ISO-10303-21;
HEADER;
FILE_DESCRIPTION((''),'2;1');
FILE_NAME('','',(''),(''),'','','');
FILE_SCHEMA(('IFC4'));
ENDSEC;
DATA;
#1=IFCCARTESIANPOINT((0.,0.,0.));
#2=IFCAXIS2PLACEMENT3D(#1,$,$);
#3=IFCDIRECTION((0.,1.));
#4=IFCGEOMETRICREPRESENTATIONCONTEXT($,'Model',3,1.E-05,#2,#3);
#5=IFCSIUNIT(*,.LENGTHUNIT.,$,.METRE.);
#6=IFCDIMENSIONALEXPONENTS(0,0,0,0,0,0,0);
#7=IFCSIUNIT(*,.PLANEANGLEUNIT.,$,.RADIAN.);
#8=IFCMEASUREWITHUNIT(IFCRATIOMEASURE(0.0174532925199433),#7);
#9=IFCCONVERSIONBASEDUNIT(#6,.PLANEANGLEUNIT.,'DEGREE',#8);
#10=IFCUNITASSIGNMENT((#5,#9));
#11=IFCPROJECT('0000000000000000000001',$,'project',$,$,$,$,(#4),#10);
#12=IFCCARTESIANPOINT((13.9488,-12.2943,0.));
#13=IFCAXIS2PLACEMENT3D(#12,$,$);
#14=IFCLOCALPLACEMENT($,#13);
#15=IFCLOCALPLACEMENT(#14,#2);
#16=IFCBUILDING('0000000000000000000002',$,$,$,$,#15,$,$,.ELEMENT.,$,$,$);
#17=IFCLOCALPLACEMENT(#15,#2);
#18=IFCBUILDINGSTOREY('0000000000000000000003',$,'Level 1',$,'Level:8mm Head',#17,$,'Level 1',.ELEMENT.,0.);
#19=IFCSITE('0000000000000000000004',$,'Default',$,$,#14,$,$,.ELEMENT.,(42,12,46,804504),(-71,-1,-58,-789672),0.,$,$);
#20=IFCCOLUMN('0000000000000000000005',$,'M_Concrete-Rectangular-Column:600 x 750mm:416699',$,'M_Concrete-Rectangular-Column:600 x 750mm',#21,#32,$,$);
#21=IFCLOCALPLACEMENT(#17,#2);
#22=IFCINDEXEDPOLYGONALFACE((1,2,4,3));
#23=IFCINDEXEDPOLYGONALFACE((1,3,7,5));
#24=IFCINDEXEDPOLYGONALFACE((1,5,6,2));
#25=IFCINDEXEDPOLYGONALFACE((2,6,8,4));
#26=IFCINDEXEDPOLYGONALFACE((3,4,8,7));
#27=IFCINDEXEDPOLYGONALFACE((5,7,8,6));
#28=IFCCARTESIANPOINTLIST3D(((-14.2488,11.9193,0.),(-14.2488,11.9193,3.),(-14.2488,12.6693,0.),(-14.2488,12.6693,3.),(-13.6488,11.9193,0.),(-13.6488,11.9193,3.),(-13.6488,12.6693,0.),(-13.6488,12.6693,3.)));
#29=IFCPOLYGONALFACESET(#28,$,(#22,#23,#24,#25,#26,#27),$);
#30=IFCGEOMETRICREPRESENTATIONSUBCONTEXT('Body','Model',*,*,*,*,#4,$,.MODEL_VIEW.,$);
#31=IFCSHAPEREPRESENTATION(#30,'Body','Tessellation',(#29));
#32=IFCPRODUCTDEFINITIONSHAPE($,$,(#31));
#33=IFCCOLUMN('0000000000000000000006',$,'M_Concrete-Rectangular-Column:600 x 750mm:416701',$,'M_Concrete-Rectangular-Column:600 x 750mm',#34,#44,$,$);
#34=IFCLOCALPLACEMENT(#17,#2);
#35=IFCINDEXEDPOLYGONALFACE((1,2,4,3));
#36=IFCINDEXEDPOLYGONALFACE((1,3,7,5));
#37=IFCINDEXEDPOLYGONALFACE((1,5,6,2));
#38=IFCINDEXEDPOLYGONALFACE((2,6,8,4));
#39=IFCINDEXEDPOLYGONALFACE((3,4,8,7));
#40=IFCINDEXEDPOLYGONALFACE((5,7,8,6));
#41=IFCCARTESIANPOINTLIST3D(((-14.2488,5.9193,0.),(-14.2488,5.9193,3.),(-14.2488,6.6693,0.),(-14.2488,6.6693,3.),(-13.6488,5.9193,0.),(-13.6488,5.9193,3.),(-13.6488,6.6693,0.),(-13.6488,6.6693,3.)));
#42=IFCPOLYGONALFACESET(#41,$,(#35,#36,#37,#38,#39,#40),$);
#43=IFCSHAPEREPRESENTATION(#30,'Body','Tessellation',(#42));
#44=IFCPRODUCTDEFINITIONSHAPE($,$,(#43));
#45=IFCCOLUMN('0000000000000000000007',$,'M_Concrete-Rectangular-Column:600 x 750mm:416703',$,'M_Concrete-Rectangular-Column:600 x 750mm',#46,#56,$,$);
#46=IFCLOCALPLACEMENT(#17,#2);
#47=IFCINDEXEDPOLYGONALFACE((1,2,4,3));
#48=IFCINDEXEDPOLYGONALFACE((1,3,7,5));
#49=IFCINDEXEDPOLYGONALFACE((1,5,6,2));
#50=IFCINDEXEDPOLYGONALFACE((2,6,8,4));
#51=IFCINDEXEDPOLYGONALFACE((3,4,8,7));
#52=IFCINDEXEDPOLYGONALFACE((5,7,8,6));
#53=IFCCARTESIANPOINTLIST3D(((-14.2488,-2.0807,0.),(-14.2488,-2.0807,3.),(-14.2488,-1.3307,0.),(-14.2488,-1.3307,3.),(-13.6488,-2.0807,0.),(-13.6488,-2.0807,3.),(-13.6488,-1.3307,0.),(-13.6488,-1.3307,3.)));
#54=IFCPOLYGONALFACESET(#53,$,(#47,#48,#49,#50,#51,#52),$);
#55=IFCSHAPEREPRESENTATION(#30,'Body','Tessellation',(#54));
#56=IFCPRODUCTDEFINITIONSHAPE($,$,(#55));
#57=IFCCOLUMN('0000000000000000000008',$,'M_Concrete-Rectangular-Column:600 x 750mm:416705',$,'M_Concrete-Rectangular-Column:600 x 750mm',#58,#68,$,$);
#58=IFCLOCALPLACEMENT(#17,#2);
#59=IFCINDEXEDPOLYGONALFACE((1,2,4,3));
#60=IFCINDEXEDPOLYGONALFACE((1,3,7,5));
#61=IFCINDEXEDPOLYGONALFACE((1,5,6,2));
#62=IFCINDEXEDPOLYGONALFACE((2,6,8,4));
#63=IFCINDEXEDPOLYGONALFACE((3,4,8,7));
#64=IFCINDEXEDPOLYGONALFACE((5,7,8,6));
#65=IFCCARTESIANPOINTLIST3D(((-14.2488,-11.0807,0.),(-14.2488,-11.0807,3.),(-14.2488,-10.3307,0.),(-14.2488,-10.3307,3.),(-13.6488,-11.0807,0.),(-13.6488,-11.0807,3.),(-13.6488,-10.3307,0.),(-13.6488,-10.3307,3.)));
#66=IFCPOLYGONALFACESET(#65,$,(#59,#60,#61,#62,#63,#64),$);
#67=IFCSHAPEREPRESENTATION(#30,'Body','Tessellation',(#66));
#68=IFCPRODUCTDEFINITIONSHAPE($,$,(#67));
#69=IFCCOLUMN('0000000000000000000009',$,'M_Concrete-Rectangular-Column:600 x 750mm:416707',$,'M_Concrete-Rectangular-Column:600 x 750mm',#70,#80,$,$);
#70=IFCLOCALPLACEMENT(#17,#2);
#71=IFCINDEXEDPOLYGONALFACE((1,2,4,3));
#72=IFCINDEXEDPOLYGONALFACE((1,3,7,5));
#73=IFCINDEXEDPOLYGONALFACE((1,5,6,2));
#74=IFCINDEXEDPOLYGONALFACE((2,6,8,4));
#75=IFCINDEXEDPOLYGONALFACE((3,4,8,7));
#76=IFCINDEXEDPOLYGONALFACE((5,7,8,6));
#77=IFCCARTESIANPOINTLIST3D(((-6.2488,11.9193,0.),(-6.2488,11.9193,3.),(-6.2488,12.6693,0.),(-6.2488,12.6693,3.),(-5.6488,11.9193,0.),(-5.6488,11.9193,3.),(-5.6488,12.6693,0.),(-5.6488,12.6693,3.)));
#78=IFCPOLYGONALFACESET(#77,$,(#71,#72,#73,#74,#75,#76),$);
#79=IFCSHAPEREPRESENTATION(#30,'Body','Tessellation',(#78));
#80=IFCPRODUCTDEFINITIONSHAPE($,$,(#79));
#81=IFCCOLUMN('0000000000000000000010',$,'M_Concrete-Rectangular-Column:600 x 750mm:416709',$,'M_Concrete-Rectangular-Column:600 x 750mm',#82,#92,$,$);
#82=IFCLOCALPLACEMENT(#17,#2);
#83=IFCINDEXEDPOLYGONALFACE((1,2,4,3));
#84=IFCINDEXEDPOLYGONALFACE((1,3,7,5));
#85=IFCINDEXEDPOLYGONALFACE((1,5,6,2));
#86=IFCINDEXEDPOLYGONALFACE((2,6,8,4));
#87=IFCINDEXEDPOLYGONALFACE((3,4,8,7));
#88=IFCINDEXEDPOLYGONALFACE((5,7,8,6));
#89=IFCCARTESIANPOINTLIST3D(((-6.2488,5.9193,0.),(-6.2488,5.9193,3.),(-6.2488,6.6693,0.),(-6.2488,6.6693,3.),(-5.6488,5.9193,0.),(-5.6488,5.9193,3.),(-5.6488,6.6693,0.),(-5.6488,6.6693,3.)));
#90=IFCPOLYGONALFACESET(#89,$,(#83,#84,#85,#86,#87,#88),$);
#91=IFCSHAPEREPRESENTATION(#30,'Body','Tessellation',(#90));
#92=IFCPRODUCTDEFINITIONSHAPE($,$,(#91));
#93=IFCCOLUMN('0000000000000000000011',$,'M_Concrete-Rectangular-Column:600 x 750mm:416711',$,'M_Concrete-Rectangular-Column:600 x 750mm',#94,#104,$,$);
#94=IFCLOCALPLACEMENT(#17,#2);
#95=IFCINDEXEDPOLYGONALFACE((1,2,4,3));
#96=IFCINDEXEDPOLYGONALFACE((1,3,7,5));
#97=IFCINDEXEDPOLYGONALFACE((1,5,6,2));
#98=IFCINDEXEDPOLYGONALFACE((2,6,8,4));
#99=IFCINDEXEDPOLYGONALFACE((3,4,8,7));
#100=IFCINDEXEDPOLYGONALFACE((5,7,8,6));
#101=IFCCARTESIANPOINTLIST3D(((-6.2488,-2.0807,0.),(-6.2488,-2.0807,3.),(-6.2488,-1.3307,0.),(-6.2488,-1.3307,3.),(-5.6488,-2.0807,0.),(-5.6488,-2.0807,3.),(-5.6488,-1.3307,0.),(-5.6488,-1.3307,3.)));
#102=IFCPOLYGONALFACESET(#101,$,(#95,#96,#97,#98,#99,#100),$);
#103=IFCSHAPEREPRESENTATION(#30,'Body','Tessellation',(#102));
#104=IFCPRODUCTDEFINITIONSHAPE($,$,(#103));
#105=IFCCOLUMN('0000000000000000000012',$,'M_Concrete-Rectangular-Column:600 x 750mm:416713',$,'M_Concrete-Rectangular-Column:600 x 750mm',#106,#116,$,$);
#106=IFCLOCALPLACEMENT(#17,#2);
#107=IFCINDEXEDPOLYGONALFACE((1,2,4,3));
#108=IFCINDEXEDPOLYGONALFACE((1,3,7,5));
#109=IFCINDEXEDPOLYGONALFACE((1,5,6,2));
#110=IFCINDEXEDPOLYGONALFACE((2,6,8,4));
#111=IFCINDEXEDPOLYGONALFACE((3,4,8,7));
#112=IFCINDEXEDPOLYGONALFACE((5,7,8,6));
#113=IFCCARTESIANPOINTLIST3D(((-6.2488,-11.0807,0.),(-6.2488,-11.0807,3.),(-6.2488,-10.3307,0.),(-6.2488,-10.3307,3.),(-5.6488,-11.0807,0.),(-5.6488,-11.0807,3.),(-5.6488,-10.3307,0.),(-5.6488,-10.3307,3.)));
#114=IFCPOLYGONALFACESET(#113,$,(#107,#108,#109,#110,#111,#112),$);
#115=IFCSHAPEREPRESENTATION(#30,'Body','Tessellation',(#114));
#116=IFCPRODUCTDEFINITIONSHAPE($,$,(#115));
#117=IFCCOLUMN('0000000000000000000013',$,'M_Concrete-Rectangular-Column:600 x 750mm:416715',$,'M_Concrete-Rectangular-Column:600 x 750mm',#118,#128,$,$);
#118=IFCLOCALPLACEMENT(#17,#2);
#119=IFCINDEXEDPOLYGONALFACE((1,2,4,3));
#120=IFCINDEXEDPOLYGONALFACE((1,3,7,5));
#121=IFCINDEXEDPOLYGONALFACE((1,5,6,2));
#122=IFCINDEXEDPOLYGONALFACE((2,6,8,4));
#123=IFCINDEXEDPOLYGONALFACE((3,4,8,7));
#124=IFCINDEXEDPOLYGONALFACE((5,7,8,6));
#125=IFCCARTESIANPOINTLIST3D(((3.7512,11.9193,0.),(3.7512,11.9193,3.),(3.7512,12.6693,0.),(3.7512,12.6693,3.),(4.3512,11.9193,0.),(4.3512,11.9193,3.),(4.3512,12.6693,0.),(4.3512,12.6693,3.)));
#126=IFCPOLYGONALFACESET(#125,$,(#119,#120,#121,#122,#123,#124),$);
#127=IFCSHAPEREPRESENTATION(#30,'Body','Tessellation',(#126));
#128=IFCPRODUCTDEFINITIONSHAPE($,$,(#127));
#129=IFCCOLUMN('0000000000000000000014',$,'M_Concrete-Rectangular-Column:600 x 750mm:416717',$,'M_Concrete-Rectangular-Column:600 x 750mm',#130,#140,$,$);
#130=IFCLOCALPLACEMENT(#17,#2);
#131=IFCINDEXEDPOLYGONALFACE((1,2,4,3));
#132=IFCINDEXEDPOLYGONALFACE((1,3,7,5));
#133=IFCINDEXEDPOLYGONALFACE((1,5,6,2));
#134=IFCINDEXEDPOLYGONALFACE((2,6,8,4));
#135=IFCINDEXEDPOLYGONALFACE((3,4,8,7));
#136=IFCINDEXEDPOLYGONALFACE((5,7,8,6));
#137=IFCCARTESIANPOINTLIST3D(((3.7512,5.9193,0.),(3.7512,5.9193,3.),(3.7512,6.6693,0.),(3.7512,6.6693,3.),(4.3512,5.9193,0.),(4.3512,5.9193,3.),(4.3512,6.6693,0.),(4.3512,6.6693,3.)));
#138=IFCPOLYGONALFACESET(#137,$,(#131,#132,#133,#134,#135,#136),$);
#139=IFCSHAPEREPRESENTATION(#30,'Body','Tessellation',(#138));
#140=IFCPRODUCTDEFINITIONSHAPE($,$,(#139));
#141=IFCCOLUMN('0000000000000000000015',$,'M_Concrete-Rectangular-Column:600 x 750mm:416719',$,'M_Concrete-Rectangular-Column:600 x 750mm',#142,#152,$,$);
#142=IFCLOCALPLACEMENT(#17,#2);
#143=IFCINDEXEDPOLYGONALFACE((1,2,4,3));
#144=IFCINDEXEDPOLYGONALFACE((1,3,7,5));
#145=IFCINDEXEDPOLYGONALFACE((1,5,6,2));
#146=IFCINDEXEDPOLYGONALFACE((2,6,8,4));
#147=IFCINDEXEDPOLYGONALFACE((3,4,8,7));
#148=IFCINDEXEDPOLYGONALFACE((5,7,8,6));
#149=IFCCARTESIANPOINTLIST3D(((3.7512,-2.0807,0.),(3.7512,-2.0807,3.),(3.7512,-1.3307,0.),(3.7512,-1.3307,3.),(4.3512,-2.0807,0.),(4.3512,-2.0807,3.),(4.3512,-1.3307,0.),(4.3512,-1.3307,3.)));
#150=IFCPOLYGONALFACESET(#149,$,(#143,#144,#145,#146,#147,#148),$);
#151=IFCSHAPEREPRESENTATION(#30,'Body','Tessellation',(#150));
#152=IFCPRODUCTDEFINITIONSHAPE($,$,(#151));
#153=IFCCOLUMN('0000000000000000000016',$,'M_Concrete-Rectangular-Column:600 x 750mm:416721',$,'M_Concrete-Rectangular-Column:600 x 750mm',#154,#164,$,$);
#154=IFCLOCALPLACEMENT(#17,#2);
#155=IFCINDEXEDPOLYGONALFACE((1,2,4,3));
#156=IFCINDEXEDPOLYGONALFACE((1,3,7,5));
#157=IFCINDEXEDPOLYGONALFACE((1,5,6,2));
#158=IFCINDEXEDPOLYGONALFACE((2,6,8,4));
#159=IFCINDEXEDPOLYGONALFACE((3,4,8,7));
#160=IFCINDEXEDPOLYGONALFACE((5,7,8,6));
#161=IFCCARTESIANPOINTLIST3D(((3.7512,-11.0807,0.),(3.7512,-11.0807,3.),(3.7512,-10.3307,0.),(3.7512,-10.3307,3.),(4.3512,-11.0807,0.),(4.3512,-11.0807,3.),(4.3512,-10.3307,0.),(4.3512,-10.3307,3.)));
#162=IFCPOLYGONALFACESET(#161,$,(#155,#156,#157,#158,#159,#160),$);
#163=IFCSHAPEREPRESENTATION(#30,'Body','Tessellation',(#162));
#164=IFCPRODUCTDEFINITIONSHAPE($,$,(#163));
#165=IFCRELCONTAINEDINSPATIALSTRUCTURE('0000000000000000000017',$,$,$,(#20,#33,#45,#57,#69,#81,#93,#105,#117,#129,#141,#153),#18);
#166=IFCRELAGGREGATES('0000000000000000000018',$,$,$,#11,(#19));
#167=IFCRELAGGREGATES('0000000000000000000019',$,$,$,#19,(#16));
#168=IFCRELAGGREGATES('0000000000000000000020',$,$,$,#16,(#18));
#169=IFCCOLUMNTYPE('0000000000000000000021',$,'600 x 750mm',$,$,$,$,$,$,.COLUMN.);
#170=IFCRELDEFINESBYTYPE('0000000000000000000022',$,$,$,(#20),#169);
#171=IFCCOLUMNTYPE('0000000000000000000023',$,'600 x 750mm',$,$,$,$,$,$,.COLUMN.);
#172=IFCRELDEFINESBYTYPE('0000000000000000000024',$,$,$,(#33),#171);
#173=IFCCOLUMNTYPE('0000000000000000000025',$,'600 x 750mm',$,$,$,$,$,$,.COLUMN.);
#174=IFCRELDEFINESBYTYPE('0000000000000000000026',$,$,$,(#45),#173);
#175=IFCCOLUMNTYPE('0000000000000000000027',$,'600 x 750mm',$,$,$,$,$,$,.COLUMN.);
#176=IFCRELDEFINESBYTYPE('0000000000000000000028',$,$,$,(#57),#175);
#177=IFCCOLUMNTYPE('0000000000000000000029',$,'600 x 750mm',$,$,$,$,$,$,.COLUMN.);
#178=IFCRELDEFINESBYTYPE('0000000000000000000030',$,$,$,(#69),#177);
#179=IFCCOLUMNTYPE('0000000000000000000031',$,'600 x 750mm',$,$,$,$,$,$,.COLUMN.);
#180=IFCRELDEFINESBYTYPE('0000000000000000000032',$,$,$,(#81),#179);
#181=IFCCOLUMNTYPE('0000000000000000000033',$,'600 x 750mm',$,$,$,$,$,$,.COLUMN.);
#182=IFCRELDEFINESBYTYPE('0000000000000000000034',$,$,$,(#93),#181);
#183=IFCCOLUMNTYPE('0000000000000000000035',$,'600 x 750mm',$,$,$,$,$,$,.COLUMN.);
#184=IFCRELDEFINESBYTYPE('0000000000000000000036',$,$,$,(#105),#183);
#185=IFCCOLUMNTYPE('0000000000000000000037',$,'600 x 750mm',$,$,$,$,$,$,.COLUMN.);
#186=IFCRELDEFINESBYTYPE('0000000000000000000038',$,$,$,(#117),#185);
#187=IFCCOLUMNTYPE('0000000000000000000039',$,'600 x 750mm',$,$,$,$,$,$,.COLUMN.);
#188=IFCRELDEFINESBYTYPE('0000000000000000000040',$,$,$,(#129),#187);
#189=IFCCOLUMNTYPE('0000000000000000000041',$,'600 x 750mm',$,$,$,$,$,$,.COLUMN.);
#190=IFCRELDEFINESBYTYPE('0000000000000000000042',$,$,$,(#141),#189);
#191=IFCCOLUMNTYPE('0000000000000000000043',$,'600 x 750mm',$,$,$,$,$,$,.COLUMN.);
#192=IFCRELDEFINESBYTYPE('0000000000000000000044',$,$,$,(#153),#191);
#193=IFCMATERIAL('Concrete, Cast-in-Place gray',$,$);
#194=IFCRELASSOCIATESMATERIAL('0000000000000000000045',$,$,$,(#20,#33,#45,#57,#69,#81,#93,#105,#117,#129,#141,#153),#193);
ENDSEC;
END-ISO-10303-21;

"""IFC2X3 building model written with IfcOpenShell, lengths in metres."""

from ifc_helpers import new_model, entity, si_unit, converted_unit, direction, frame, frame_2d, origin, origin_2d_with_axis, place, context, subcontext, project, spatial, rectangle, extrude, source, transform, mapped, material, type_object, type_shapes, element, save


model = new_model("IFC2X3")

# Units and contexts
model_context = context("Model", 3, precision=1e-05, world=origin(), true_north=direction((0.0, 1.0)))
body_context = subcontext(model_context, "Body", "Model", "MODEL_VIEW")
ifc_project = project(units=[si_unit("LENGTHUNIT", "METRE"), converted_unit("PLANEANGLEUNIT", "DEGREE", entity("IfcRatioMeasure", 0.0174532925199433), si_unit("PLANEANGLEUNIT", "RADIAN"), dimensions=[0, 0, 0, 0, 0, 0, 0])], contexts=[model_context])

# Site, building, storey
site_placement = place(None, frame((13.9488, -12.2943, 0.0)))
site = spatial("IfcSite", under=ifc_project, at=site_placement, Name="Default", CompositionType="ELEMENT", RefLatitude=(42, 12, 46, 804504), RefLongitude=(-71, -1, -58, -789672), RefElevation=0.0)
building_placement = place(site_placement, origin())
building = spatial("IfcBuilding", under=site, at=building_placement, CompositionType="ELEMENT")
storey_placement = place(building_placement, origin())
storey = spatial("IfcBuildingStorey", under=building, at=storey_placement, Name="Level 1", ObjectType="Level:8mm Head", LongName="Level 1", CompositionType="ELEMENT", Elevation=0.0)

# Columns
ifc_material = material(Name="Concrete, Cast-in-Place gray")
column_type_1 = type_object("IfcColumnType", Name="600 x 750mm", PredefinedType="COLUMN")
shared_shape_1 = source(origin(), body_context, "Body", "SweptSolid", [
    extrude(rectangle(XDim=0.75, YDim=0.6, at=frame_2d((0.0, 0.0), x_axis=(1.0, 0.0))), frame((-13.9488, 12.2943, 0.0), z_axis=(0.0, 0.0, 1.0), x_axis=(0.0, -1.0, 0.0)), (0.0, 0.0, 1.0), 3.0),
])
type_shapes(column_type_1, [shared_shape_1])
column_1_placement = place(storey_placement, origin())
element("IfcColumn", 1, at=column_1_placement, inside=storey, type_object=column_type_1, material=ifc_material, Name="M_Concrete-Rectangular-Column:600 x 750mm:416699", ObjectType="M_Concrete-Rectangular-Column:600 x 750mm", context=body_context, shape_type="MappedRepresentation", body=[
    mapped(shared_shape_1, transform((0.0, 0.0, 0.0), scale=1.0)),
])
column_type_2 = type_object("IfcColumnType", Name="600 x 750mm", PredefinedType="COLUMN")
shared_shape_2 = source(origin(), body_context, "Body", "SweptSolid", [
    extrude(rectangle(XDim=0.75, YDim=0.6, at=frame_2d((0.0, 0.0), x_axis=(1.0, 0.0))), frame((-13.9488, 6.2943, 0.0), z_axis=(0.0, 0.0, 1.0), x_axis=(0.0, -1.0, 0.0)), (0.0, 0.0, 1.0), 3.0),
])
type_shapes(column_type_2, [shared_shape_2])
column_2_placement = place(storey_placement, origin())
element("IfcColumn", 2, at=column_2_placement, inside=storey, type_object=column_type_2, material=ifc_material, Name="M_Concrete-Rectangular-Column:600 x 750mm:416701", ObjectType="M_Concrete-Rectangular-Column:600 x 750mm", context=body_context, shape_type="MappedRepresentation", body=[
    mapped(shared_shape_2, transform((0.0, 0.0, 0.0), scale=1.0)),
])
column_type_3 = type_object("IfcColumnType", Name="600 x 750mm", PredefinedType="COLUMN")
shared_shape_3 = source(origin(), body_context, "Body", "SweptSolid", [
    extrude(rectangle(XDim=0.75, YDim=0.6, at=frame_2d((0.0, 0.0), x_axis=(1.0, 0.0))), frame((-13.9488, -1.7057, 0.0), z_axis=(0.0, 0.0, 1.0), x_axis=(0.0, -1.0, 0.0)), (0.0, 0.0, 1.0), 3.0),
])
type_shapes(column_type_3, [shared_shape_3])
column_3_placement = place(storey_placement, origin())
element("IfcColumn", 3, at=column_3_placement, inside=storey, type_object=column_type_3, material=ifc_material, Name="M_Concrete-Rectangular-Column:600 x 750mm:416703", ObjectType="M_Concrete-Rectangular-Column:600 x 750mm", context=body_context, shape_type="MappedRepresentation", body=[
    mapped(shared_shape_3, transform((0.0, 0.0, 0.0), scale=1.0)),
])
column_type_4 = type_object("IfcColumnType", Name="600 x 750mm", PredefinedType="COLUMN")
shared_shape_4 = source(origin(), body_context, "Body", "SweptSolid", [
    extrude(rectangle(XDim=0.75, YDim=0.6, at=frame_2d((0.0, 0.0), x_axis=(1.0, 0.0))), frame((-13.9488, -10.7057, 0.0), z_axis=(0.0, 0.0, 1.0), x_axis=(0.0, -1.0, 0.0)), (0.0, 0.0, 1.0), 3.0),
])
type_shapes(column_type_4, [shared_shape_4])
column_4_placement = place(storey_placement, origin())
element("IfcColumn", 4, at=column_4_placement, inside=storey, type_object=column_type_4, material=ifc_material, Name="M_Concrete-Rectangular-Column:600 x 750mm:416705", ObjectType="M_Concrete-Rectangular-Column:600 x 750mm", context=body_context, shape_type="MappedRepresentation", body=[
    mapped(shared_shape_4, transform((0.0, 0.0, 0.0), scale=1.0)),
])
column_type_5 = type_object("IfcColumnType", Name="600 x 750mm", PredefinedType="COLUMN")
shared_shape_5 = source(origin(), body_context, "Body", "SweptSolid", [
    extrude(rectangle(XDim=0.75, YDim=0.6, at=origin_2d_with_axis()), frame((-5.9488, 12.2943, 0.0), z_axis=(0.0, 0.0, 1.0), x_axis=(0.0, -1.0, 0.0)), (0.0, 0.0, 1.0), 3.0),
])
type_shapes(column_type_5, [shared_shape_5])
column_5_placement = place(storey_placement, origin())
element("IfcColumn", 5, at=column_5_placement, inside=storey, type_object=column_type_5, material=ifc_material, Name="M_Concrete-Rectangular-Column:600 x 750mm:416707", ObjectType="M_Concrete-Rectangular-Column:600 x 750mm", context=body_context, shape_type="MappedRepresentation", body=[
    mapped(shared_shape_5, transform((0.0, 0.0, 0.0), scale=1.0)),
])
column_type_6 = type_object("IfcColumnType", Name="600 x 750mm", PredefinedType="COLUMN")
shared_shape_6 = source(origin(), body_context, "Body", "SweptSolid", [
    extrude(rectangle(XDim=0.75, YDim=0.6, at=origin_2d_with_axis()), frame((-5.9488, 6.2943, 0.0), z_axis=(0.0, 0.0, 1.0), x_axis=(0.0, -1.0, 0.0)), (0.0, 0.0, 1.0), 3.0),
])
type_shapes(column_type_6, [shared_shape_6])
column_6_placement = place(storey_placement, origin())
element("IfcColumn", 6, at=column_6_placement, inside=storey, type_object=column_type_6, material=ifc_material, Name="M_Concrete-Rectangular-Column:600 x 750mm:416709", ObjectType="M_Concrete-Rectangular-Column:600 x 750mm", context=body_context, shape_type="MappedRepresentation", body=[
    mapped(shared_shape_6, transform((0.0, 0.0, 0.0), scale=1.0)),
])
column_type_7 = type_object("IfcColumnType", Name="600 x 750mm", PredefinedType="COLUMN")
shared_shape_7 = source(origin(), body_context, "Body", "SweptSolid", [
    extrude(rectangle(XDim=0.75, YDim=0.6, at=frame_2d((0.0, 0.0), x_axis=(1.0, 0.0))), frame((-5.9488, -1.7057, 0.0), z_axis=(0.0, 0.0, 1.0), x_axis=(0.0, -1.0, 0.0)), (0.0, 0.0, 1.0), 3.0),
])
type_shapes(column_type_7, [shared_shape_7])
column_7_placement = place(storey_placement, origin())
element("IfcColumn", 7, at=column_7_placement, inside=storey, type_object=column_type_7, material=ifc_material, Name="M_Concrete-Rectangular-Column:600 x 750mm:416711", ObjectType="M_Concrete-Rectangular-Column:600 x 750mm", context=body_context, shape_type="MappedRepresentation", body=[
    mapped(shared_shape_7, transform((0.0, 0.0, 0.0), scale=1.0)),
])
column_type_8 = type_object("IfcColumnType", Name="600 x 750mm", PredefinedType="COLUMN")
shared_shape_8 = source(origin(), body_context, "Body", "SweptSolid", [
    extrude(rectangle(XDim=0.75, YDim=0.6, at=origin_2d_with_axis()), frame((-5.9488, -10.7057, 0.0), z_axis=(0.0, 0.0, 1.0), x_axis=(0.0, -1.0, 0.0)), (0.0, 0.0, 1.0), 3.0),
])
type_shapes(column_type_8, [shared_shape_8])
column_8_placement = place(storey_placement, origin())
element("IfcColumn", 8, at=column_8_placement, inside=storey, type_object=column_type_8, material=ifc_material, Name="M_Concrete-Rectangular-Column:600 x 750mm:416713", ObjectType="M_Concrete-Rectangular-Column:600 x 750mm", context=body_context, shape_type="MappedRepresentation", body=[
    mapped(shared_shape_8, transform((0.0, 0.0, 0.0), scale=1.0)),
])
column_type_9 = type_object("IfcColumnType", Name="600 x 750mm", PredefinedType="COLUMN")
shared_shape_9 = source(origin(), body_context, "Body", "SweptSolid", [
    extrude(rectangle(XDim=0.75, YDim=0.6, at=origin_2d_with_axis()), frame((4.0512, 12.2943, 0.0), z_axis=(0.0, 0.0, 1.0), x_axis=(0.0, -1.0, 0.0)), (0.0, 0.0, 1.0), 3.0),
])
type_shapes(column_type_9, [shared_shape_9])
column_9_placement = place(storey_placement, origin())
element("IfcColumn", 9, at=column_9_placement, inside=storey, type_object=column_type_9, material=ifc_material, Name="M_Concrete-Rectangular-Column:600 x 750mm:416715", ObjectType="M_Concrete-Rectangular-Column:600 x 750mm", context=body_context, shape_type="MappedRepresentation", body=[
    mapped(shared_shape_9, transform((0.0, 0.0, 0.0), scale=1.0)),
])
column_type_10 = type_object("IfcColumnType", Name="600 x 750mm", PredefinedType="COLUMN")
shared_shape_10 = source(origin(), body_context, "Body", "SweptSolid", [
    extrude(rectangle(XDim=0.75, YDim=0.6, at=origin_2d_with_axis()), frame((4.0512, 6.2943, 0.0), z_axis=(0.0, 0.0, 1.0), x_axis=(0.0, -1.0, 0.0)), (0.0, 0.0, 1.0), 3.0),
])
type_shapes(column_type_10, [shared_shape_10])
column_10_placement = place(storey_placement, origin())
element("IfcColumn", 10, at=column_10_placement, inside=storey, type_object=column_type_10, material=ifc_material, Name="M_Concrete-Rectangular-Column:600 x 750mm:416717", ObjectType="M_Concrete-Rectangular-Column:600 x 750mm", context=body_context, shape_type="MappedRepresentation", body=[
    mapped(shared_shape_10, transform((0.0, 0.0, 0.0), scale=1.0)),
])
column_type_11 = type_object("IfcColumnType", Name="600 x 750mm", PredefinedType="COLUMN")
shared_shape_11 = source(origin(), body_context, "Body", "SweptSolid", [
    extrude(rectangle(XDim=0.75, YDim=0.6, at=frame_2d((0.0, 0.0), x_axis=(1.0, 0.0))), frame((4.0512, -1.7057, 0.0), z_axis=(0.0, 0.0, 1.0), x_axis=(0.0, -1.0, 0.0)), (0.0, 0.0, 1.0), 3.0),
])
type_shapes(column_type_11, [shared_shape_11])
column_11_placement = place(storey_placement, origin())
element("IfcColumn", 11, at=column_11_placement, inside=storey, type_object=column_type_11, material=ifc_material, Name="M_Concrete-Rectangular-Column:600 x 750mm:416719", ObjectType="M_Concrete-Rectangular-Column:600 x 750mm", context=body_context, shape_type="MappedRepresentation", body=[
    mapped(shared_shape_11, transform((0.0, 0.0, 0.0), scale=1.0)),
])
column_type_12 = type_object("IfcColumnType", Name="600 x 750mm", PredefinedType="COLUMN")
shared_shape_12 = source(origin(), body_context, "Body", "SweptSolid", [
    extrude(rectangle(XDim=0.75, YDim=0.6, at=origin_2d_with_axis()), frame((4.0512, -10.7057, 0.0), z_axis=(0.0, 0.0, 1.0), x_axis=(0.0, -1.0, 0.0)), (0.0, 0.0, 1.0), 3.0),
])
type_shapes(column_type_12, [shared_shape_12])
column_12_placement = place(storey_placement, origin())
element("IfcColumn", 12, at=column_12_placement, inside=storey, type_object=column_type_12, material=ifc_material, Name="M_Concrete-Rectangular-Column:600 x 750mm:416721", ObjectType="M_Concrete-Rectangular-Column:600 x 750mm", context=body_context, shape_type="MappedRepresentation", body=[
    mapped(shared_shape_12, transform((0.0, 0.0, 0.0), scale=1.0)),
])

save(model, "model.ifc")
